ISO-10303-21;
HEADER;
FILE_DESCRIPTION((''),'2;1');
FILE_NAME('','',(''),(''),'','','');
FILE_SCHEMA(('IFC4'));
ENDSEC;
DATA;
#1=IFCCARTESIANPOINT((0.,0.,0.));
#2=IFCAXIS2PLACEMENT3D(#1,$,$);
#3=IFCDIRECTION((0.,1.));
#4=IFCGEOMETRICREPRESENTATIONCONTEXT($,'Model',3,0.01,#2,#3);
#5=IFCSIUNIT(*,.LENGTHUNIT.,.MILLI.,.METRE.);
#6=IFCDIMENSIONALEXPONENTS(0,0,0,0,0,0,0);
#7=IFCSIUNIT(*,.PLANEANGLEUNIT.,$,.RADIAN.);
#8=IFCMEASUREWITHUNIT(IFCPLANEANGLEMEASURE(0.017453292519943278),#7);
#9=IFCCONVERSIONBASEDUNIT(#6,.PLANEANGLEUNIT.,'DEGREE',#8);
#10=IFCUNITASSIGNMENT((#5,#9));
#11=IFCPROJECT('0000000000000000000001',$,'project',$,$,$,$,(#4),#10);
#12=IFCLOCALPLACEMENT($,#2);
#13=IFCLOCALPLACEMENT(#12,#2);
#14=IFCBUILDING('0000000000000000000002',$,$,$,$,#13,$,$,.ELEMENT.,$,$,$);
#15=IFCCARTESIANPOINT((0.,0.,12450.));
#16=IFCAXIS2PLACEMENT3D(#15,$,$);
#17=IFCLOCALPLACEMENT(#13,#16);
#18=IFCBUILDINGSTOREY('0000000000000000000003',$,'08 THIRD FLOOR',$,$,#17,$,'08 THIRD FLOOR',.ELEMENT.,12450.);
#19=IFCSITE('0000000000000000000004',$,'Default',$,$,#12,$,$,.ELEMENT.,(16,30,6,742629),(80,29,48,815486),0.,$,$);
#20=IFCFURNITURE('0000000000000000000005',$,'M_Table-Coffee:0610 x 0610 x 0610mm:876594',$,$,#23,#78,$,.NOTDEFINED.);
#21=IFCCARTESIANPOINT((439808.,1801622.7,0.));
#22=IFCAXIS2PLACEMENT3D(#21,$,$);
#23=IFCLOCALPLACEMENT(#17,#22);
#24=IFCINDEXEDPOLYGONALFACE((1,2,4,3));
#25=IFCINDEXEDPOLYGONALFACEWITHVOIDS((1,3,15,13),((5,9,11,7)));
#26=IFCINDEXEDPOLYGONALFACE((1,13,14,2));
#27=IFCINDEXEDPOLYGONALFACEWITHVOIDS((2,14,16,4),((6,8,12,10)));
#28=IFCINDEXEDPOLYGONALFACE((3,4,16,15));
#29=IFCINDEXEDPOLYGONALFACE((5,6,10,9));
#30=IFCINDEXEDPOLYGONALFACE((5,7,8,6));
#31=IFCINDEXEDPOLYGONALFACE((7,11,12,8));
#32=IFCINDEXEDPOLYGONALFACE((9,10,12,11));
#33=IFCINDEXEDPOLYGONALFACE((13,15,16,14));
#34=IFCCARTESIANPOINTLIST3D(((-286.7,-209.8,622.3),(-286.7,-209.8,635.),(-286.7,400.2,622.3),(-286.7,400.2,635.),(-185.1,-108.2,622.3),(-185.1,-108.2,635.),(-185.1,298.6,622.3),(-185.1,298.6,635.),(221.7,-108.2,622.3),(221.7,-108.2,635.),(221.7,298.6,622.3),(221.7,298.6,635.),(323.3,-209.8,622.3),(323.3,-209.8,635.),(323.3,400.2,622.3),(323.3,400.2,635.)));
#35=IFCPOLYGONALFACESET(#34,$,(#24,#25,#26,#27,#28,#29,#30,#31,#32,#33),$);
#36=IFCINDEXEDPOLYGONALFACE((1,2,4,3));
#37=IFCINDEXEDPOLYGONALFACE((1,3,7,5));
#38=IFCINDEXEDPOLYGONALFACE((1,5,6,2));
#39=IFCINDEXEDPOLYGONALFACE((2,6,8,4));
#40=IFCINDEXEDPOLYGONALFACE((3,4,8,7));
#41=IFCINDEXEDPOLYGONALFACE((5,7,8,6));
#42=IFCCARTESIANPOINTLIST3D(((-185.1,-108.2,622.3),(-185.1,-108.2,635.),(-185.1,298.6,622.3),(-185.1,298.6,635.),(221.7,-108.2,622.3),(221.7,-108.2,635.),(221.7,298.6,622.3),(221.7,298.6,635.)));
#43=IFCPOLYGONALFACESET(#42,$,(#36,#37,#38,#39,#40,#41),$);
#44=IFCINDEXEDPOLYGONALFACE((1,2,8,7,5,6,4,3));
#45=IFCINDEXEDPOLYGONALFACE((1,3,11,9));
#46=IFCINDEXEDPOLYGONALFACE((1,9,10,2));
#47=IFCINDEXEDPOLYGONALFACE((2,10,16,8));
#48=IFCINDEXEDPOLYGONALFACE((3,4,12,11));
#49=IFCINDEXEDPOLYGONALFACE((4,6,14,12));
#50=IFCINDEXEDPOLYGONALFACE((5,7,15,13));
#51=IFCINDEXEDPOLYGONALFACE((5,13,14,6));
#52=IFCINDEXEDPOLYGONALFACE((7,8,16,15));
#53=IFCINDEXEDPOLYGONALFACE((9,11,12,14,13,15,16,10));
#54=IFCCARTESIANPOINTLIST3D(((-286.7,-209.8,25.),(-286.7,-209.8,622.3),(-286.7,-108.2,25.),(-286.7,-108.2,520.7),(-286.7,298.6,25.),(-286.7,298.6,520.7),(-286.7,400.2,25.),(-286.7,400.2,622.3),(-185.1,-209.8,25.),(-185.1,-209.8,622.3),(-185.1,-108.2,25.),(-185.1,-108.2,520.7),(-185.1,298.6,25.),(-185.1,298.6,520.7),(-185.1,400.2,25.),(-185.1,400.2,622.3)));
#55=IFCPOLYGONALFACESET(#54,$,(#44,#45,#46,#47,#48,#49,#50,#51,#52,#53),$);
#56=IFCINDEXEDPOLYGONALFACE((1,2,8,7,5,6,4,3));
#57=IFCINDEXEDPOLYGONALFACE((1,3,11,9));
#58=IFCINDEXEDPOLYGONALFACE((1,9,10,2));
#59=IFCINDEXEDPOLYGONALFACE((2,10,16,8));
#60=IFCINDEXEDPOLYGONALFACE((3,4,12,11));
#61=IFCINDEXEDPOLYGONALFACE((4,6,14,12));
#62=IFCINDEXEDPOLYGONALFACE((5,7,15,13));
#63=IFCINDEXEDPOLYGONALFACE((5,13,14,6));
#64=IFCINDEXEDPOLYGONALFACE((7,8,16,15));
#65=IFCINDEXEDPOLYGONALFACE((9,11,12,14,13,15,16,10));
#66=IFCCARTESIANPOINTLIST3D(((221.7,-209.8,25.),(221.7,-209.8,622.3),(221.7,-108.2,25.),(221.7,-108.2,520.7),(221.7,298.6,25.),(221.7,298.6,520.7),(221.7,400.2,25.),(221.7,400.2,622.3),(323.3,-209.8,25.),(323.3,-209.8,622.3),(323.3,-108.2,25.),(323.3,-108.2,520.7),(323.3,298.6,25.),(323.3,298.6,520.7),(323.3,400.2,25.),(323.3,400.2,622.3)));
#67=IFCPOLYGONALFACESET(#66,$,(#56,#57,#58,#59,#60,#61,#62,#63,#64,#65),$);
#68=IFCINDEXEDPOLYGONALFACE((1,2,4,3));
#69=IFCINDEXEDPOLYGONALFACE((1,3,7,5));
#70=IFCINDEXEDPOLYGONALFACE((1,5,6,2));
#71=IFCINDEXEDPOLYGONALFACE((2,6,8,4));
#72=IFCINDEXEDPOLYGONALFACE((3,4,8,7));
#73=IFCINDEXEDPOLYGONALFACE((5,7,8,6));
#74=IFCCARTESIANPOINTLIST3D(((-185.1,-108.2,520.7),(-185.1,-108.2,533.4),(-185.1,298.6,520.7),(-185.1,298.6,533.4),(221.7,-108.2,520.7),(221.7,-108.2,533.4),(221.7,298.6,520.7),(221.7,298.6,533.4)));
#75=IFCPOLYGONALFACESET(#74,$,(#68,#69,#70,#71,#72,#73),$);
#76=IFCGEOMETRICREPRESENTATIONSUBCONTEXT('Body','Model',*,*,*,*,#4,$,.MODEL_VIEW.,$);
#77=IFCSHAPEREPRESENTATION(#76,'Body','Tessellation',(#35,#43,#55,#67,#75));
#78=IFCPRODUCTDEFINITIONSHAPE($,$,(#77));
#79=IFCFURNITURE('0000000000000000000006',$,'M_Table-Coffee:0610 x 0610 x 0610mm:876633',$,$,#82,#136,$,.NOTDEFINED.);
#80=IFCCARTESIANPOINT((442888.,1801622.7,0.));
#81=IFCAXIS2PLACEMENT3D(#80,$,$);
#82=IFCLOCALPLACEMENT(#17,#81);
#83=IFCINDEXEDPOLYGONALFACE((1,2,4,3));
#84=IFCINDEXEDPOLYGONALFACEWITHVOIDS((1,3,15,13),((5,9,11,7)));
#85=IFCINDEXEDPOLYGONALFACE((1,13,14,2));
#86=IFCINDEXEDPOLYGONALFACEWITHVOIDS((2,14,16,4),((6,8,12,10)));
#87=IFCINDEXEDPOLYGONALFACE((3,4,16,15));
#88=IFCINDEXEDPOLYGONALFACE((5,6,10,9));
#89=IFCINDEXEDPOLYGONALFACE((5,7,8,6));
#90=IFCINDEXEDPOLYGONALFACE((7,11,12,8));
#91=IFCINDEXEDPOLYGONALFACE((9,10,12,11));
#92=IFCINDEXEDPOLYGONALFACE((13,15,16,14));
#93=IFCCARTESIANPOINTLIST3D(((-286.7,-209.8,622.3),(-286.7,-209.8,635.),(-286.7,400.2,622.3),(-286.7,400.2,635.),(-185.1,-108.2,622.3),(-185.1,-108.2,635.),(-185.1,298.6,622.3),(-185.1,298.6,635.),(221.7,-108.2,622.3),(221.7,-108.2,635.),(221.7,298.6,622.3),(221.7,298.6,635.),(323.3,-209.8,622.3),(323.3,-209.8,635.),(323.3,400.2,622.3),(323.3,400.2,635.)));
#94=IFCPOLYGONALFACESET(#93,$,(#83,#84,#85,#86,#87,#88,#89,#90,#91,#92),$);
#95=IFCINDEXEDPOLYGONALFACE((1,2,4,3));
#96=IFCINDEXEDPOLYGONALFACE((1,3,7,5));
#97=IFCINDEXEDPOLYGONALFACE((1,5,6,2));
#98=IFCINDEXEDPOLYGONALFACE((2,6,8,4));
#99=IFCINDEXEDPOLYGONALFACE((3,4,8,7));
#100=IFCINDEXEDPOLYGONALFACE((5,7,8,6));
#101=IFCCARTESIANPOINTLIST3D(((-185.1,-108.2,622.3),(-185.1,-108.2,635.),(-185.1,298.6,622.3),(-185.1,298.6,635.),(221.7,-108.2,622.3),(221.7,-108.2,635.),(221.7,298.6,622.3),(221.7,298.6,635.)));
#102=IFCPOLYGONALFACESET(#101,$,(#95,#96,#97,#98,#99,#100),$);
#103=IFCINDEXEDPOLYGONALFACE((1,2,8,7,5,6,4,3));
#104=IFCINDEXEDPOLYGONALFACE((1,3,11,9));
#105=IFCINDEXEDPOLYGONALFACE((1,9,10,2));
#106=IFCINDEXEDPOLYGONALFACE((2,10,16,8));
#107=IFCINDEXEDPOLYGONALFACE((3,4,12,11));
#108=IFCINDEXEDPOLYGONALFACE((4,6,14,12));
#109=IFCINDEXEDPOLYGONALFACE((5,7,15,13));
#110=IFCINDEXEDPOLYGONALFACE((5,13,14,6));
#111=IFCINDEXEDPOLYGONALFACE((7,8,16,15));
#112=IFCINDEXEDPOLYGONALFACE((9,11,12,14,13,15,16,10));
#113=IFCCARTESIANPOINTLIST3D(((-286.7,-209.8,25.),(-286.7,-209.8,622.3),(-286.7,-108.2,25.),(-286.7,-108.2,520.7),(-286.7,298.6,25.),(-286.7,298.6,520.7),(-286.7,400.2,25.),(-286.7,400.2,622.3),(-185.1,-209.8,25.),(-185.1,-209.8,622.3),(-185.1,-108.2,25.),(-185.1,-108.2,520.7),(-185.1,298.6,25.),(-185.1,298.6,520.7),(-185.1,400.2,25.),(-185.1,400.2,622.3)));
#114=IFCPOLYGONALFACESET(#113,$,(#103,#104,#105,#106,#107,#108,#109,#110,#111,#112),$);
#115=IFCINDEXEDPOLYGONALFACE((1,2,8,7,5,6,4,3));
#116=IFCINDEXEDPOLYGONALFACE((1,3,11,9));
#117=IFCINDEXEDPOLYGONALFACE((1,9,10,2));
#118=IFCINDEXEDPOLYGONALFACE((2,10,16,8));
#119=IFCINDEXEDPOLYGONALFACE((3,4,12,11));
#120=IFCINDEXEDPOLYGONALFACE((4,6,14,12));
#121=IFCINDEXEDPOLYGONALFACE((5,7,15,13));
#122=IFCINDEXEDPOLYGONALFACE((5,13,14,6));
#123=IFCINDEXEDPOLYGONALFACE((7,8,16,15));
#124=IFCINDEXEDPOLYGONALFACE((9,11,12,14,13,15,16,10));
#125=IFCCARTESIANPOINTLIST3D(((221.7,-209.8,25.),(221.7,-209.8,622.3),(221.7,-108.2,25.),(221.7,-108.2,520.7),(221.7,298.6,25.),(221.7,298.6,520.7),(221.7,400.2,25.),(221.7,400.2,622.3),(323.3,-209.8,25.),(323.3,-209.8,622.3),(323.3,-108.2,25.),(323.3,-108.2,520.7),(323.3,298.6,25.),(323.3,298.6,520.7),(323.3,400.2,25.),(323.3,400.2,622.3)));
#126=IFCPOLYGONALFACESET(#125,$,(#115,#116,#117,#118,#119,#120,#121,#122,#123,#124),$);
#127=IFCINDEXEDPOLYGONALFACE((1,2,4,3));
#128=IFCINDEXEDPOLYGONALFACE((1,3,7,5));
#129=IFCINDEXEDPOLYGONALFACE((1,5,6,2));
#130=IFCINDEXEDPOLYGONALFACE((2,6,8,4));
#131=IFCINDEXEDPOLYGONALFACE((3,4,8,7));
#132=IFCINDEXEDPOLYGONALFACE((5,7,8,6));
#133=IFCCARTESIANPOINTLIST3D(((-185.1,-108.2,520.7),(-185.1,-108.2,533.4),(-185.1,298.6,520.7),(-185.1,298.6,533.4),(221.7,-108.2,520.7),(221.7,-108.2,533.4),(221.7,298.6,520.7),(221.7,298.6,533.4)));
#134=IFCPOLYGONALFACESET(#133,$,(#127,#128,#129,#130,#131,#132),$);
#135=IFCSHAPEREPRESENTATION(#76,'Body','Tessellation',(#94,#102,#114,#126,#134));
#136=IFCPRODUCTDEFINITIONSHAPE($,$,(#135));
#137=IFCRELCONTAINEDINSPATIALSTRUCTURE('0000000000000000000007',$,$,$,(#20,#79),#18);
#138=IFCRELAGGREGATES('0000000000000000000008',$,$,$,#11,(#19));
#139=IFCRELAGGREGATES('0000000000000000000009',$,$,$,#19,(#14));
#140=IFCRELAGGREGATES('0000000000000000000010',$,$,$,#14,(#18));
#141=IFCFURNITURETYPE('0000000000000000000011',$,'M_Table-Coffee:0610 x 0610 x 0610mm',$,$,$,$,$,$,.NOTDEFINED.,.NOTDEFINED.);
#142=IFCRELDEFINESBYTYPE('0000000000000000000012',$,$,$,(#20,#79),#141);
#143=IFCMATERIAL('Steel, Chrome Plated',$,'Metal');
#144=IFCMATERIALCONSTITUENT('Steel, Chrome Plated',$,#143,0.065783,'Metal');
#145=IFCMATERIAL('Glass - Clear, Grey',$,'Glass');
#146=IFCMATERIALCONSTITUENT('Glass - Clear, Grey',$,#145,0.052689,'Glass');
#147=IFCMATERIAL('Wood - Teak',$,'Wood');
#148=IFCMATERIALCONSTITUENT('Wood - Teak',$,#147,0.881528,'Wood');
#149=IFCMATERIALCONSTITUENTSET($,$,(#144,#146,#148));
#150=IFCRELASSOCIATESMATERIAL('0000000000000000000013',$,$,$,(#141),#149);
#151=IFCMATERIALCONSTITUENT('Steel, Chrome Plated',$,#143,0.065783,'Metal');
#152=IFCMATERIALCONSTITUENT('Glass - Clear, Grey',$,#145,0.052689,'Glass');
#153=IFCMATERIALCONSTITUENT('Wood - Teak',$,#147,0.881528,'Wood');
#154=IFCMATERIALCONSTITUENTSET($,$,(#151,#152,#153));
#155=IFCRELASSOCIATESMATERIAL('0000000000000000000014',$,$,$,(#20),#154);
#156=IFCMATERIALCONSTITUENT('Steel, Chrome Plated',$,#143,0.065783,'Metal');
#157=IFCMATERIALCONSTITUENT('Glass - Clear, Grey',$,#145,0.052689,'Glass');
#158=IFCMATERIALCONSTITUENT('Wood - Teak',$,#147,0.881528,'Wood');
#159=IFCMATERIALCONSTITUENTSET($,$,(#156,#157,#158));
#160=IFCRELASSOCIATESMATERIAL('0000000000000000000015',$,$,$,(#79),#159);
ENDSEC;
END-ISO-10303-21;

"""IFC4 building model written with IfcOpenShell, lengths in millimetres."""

from ifc_helpers import new_model, entity, si_unit, converted_unit, direction, frame, origin, place, context, subcontext, project, spatial, indexed_curve, outline, extrude, source, transform, mapped, material, constituent, constituent_set, type_object, type_shapes, element, save


model = new_model("IFC4")

# Units and contexts
model_context = context("Model", 3, precision=0.01, world=origin(), true_north=direction((0.0, 1.0)))
body_context = subcontext(model_context, "Body", "Model", "MODEL_VIEW")
ifc_project = project(units=[si_unit("LENGTHUNIT", "METRE", prefix="MILLI"), converted_unit("PLANEANGLEUNIT", "DEGREE", entity("IfcPlaneAngleMeasure", 0.017453292519943278), si_unit("PLANEANGLEUNIT", "RADIAN"), dimensions=[0, 0, 0, 0, 0, 0, 0])], contexts=[model_context])

# Site, building, storey
site_placement = place(None, origin())
site = spatial("IfcSite", under=ifc_project, at=site_placement, Name="Default", CompositionType="ELEMENT", RefLatitude=(16, 30, 6, 742629), RefLongitude=(80, 29, 48, 815486), RefElevation=0.0)
building_placement = place(site_placement, origin())
building = spatial("IfcBuilding", under=site, at=building_placement, CompositionType="ELEMENT")
storey_placement = place(building_placement, frame((0.0, 0.0, 12450.0)))
storey = spatial("IfcBuildingStorey", under=building, at=storey_placement, Name="08 THIRD FLOOR", LongName="08 THIRD FLOOR", CompositionType="ELEMENT", Elevation=12450.0)

# Shared definitions
ifc_material_1 = material(Name="Steel, Chrome Plated", Category="Metal")
ifc_material_2 = material(Name="Glass - Clear, Grey", Category="Glass")
ifc_material_3 = material(Name="Wood - Teak", Category="Wood")
ifc_constituent_1 = constituent(ifc_material_1, Name="Steel, Chrome Plated", Category="Metal", fraction=0.065783)
ifc_constituent_2 = constituent(ifc_material_2, Name="Glass - Clear, Grey", Category="Glass", fraction=0.052689)
ifc_constituent_3 = constituent(ifc_material_3, Name="Wood - Teak", Category="Wood", fraction=0.881528)
ifc_constituent_set_1 = constituent_set(constituents=[ifc_constituent_1, ifc_constituent_2, ifc_constituent_3])
furniture_type_1 = type_object("IfcFurnitureType", Name="M_Table-Coffee:0610 x 0610 x 0610mm", AssemblyPlace="NOTDEFINED", PredefinedType="NOTDEFINED", material=ifc_constituent_set_1)
shared_shape_1 = source(origin(), body_context, "Body", "SweptSolid", [
    extrude(outline(indexed_curve([(-305.0, -305.0), (305.0, -305.0), (305.0, 305.0), (-305.0, 305.0), (-305.0, -305.0)], self_intersect=False), holes=[indexed_curve([(-203.4, -203.4), (-203.4, 203.4), (203.4, 203.4), (203.4, -203.4), (-203.4, -203.4)], self_intersect=False)]), frame((18.3, 95.2, 622.3), z_axis=(0.0, 0.0, 1.0), x_axis=(-1.0, 0.0, 0.0)), (0.0, 0.0, 1.0), 12.7),
    extrude(outline(indexed_curve([(-203.4, -203.4), (203.4, -203.4), (203.4, 203.4), (-203.4, 203.4), (-203.4, -203.4)], self_intersect=False)), frame((18.3, 95.2, 622.3), z_axis=(0.0, 0.0, 1.0), x_axis=(-1.0, 0.0, 0.0)), (0.0, 0.0, 1.0), 12.7),
    extrude(outline(indexed_curve([(-305.0, -324.1), (305.0, -324.1), (305.0, 273.3), (203.4, 273.3), (203.4, -222.4), (-203.4, -222.4), (-203.4, 273.3), (-305.0, 273.3), (-305.0, -324.1)], self_intersect=False)), frame((-286.7, 95.2, 298.3), z_axis=(1.0, 0.0, 0.0), x_axis=(0.0, -1.0, 0.0)), (0.0, 0.0, 1.0), 101.6),
    extrude(outline(indexed_curve([(-273.2, -305.0), (324.0, -305.0), (324.0, 305.0), (-273.2, 305.0), (-273.2, 203.4), (222.5, 203.4), (222.5, -203.4), (-273.2, -203.4), (-273.2, -305.0)], self_intersect=False)), frame((221.7, 95.2, 298.2), z_axis=(1.0, 0.0, 0.0), x_axis=(0.0, 0.0, 1.0)), (0.0, 0.0, 1.0), 101.6),
    extrude(outline(indexed_curve([(-203.4, -203.4), (203.4, -203.4), (203.4, 203.4), (-203.4, 203.4), (-203.4, -203.4)], self_intersect=False)), frame((18.3, 95.2, 520.7), z_axis=(0.0, 0.0, 1.0), x_axis=(-1.0, 0.0, 0.0)), (0.0, 0.0, 1.0), 12.7),
])
type_shapes(furniture_type_1, [shared_shape_1])

# Furniture
ifc_constituent_4 = constituent(ifc_material_1, Name="Steel, Chrome Plated", Category="Metal", fraction=0.065783)
ifc_constituent_5 = constituent(ifc_material_2, Name="Glass - Clear, Grey", Category="Glass", fraction=0.052689)
ifc_constituent_6 = constituent(ifc_material_3, Name="Wood - Teak", Category="Wood", fraction=0.881528)
ifc_constituent_set_2 = constituent_set(constituents=[ifc_constituent_4, ifc_constituent_5, ifc_constituent_6])
furniture_1_placement = place(storey_placement, frame((439808.0, 1801622.7, 0.0)))
element("IfcFurniture", 1, at=furniture_1_placement, inside=storey, type_object=furniture_type_1, material=ifc_constituent_set_2, Name="M_Table-Coffee:0610 x 0610 x 0610mm:876594", PredefinedType="NOTDEFINED", context=body_context, shape_type="MappedRepresentation", body=[
    mapped(shared_shape_1, transform((0.0, 0.0, 0.0), scale=1.0)),
])
ifc_constituent_7 = constituent(ifc_material_1, Name="Steel, Chrome Plated", Category="Metal", fraction=0.065783)
ifc_constituent_8 = constituent(ifc_material_2, Name="Glass - Clear, Grey", Category="Glass", fraction=0.052689)
ifc_constituent_9 = constituent(ifc_material_3, Name="Wood - Teak", Category="Wood", fraction=0.881528)
ifc_constituent_set_3 = constituent_set(constituents=[ifc_constituent_7, ifc_constituent_8, ifc_constituent_9])
furniture_2_placement = place(storey_placement, frame((442888.0, 1801622.7, 0.0)))
element("IfcFurniture", 2, at=furniture_2_placement, inside=storey, type_object=furniture_type_1, material=ifc_constituent_set_3, Name="M_Table-Coffee:0610 x 0610 x 0610mm:876633", PredefinedType="NOTDEFINED", context=body_context, shape_type="MappedRepresentation", body=[
    mapped(shared_shape_1, transform((0.0, 0.0, 0.0), scale=1.0)),
])

save(model, "model.ifc")
